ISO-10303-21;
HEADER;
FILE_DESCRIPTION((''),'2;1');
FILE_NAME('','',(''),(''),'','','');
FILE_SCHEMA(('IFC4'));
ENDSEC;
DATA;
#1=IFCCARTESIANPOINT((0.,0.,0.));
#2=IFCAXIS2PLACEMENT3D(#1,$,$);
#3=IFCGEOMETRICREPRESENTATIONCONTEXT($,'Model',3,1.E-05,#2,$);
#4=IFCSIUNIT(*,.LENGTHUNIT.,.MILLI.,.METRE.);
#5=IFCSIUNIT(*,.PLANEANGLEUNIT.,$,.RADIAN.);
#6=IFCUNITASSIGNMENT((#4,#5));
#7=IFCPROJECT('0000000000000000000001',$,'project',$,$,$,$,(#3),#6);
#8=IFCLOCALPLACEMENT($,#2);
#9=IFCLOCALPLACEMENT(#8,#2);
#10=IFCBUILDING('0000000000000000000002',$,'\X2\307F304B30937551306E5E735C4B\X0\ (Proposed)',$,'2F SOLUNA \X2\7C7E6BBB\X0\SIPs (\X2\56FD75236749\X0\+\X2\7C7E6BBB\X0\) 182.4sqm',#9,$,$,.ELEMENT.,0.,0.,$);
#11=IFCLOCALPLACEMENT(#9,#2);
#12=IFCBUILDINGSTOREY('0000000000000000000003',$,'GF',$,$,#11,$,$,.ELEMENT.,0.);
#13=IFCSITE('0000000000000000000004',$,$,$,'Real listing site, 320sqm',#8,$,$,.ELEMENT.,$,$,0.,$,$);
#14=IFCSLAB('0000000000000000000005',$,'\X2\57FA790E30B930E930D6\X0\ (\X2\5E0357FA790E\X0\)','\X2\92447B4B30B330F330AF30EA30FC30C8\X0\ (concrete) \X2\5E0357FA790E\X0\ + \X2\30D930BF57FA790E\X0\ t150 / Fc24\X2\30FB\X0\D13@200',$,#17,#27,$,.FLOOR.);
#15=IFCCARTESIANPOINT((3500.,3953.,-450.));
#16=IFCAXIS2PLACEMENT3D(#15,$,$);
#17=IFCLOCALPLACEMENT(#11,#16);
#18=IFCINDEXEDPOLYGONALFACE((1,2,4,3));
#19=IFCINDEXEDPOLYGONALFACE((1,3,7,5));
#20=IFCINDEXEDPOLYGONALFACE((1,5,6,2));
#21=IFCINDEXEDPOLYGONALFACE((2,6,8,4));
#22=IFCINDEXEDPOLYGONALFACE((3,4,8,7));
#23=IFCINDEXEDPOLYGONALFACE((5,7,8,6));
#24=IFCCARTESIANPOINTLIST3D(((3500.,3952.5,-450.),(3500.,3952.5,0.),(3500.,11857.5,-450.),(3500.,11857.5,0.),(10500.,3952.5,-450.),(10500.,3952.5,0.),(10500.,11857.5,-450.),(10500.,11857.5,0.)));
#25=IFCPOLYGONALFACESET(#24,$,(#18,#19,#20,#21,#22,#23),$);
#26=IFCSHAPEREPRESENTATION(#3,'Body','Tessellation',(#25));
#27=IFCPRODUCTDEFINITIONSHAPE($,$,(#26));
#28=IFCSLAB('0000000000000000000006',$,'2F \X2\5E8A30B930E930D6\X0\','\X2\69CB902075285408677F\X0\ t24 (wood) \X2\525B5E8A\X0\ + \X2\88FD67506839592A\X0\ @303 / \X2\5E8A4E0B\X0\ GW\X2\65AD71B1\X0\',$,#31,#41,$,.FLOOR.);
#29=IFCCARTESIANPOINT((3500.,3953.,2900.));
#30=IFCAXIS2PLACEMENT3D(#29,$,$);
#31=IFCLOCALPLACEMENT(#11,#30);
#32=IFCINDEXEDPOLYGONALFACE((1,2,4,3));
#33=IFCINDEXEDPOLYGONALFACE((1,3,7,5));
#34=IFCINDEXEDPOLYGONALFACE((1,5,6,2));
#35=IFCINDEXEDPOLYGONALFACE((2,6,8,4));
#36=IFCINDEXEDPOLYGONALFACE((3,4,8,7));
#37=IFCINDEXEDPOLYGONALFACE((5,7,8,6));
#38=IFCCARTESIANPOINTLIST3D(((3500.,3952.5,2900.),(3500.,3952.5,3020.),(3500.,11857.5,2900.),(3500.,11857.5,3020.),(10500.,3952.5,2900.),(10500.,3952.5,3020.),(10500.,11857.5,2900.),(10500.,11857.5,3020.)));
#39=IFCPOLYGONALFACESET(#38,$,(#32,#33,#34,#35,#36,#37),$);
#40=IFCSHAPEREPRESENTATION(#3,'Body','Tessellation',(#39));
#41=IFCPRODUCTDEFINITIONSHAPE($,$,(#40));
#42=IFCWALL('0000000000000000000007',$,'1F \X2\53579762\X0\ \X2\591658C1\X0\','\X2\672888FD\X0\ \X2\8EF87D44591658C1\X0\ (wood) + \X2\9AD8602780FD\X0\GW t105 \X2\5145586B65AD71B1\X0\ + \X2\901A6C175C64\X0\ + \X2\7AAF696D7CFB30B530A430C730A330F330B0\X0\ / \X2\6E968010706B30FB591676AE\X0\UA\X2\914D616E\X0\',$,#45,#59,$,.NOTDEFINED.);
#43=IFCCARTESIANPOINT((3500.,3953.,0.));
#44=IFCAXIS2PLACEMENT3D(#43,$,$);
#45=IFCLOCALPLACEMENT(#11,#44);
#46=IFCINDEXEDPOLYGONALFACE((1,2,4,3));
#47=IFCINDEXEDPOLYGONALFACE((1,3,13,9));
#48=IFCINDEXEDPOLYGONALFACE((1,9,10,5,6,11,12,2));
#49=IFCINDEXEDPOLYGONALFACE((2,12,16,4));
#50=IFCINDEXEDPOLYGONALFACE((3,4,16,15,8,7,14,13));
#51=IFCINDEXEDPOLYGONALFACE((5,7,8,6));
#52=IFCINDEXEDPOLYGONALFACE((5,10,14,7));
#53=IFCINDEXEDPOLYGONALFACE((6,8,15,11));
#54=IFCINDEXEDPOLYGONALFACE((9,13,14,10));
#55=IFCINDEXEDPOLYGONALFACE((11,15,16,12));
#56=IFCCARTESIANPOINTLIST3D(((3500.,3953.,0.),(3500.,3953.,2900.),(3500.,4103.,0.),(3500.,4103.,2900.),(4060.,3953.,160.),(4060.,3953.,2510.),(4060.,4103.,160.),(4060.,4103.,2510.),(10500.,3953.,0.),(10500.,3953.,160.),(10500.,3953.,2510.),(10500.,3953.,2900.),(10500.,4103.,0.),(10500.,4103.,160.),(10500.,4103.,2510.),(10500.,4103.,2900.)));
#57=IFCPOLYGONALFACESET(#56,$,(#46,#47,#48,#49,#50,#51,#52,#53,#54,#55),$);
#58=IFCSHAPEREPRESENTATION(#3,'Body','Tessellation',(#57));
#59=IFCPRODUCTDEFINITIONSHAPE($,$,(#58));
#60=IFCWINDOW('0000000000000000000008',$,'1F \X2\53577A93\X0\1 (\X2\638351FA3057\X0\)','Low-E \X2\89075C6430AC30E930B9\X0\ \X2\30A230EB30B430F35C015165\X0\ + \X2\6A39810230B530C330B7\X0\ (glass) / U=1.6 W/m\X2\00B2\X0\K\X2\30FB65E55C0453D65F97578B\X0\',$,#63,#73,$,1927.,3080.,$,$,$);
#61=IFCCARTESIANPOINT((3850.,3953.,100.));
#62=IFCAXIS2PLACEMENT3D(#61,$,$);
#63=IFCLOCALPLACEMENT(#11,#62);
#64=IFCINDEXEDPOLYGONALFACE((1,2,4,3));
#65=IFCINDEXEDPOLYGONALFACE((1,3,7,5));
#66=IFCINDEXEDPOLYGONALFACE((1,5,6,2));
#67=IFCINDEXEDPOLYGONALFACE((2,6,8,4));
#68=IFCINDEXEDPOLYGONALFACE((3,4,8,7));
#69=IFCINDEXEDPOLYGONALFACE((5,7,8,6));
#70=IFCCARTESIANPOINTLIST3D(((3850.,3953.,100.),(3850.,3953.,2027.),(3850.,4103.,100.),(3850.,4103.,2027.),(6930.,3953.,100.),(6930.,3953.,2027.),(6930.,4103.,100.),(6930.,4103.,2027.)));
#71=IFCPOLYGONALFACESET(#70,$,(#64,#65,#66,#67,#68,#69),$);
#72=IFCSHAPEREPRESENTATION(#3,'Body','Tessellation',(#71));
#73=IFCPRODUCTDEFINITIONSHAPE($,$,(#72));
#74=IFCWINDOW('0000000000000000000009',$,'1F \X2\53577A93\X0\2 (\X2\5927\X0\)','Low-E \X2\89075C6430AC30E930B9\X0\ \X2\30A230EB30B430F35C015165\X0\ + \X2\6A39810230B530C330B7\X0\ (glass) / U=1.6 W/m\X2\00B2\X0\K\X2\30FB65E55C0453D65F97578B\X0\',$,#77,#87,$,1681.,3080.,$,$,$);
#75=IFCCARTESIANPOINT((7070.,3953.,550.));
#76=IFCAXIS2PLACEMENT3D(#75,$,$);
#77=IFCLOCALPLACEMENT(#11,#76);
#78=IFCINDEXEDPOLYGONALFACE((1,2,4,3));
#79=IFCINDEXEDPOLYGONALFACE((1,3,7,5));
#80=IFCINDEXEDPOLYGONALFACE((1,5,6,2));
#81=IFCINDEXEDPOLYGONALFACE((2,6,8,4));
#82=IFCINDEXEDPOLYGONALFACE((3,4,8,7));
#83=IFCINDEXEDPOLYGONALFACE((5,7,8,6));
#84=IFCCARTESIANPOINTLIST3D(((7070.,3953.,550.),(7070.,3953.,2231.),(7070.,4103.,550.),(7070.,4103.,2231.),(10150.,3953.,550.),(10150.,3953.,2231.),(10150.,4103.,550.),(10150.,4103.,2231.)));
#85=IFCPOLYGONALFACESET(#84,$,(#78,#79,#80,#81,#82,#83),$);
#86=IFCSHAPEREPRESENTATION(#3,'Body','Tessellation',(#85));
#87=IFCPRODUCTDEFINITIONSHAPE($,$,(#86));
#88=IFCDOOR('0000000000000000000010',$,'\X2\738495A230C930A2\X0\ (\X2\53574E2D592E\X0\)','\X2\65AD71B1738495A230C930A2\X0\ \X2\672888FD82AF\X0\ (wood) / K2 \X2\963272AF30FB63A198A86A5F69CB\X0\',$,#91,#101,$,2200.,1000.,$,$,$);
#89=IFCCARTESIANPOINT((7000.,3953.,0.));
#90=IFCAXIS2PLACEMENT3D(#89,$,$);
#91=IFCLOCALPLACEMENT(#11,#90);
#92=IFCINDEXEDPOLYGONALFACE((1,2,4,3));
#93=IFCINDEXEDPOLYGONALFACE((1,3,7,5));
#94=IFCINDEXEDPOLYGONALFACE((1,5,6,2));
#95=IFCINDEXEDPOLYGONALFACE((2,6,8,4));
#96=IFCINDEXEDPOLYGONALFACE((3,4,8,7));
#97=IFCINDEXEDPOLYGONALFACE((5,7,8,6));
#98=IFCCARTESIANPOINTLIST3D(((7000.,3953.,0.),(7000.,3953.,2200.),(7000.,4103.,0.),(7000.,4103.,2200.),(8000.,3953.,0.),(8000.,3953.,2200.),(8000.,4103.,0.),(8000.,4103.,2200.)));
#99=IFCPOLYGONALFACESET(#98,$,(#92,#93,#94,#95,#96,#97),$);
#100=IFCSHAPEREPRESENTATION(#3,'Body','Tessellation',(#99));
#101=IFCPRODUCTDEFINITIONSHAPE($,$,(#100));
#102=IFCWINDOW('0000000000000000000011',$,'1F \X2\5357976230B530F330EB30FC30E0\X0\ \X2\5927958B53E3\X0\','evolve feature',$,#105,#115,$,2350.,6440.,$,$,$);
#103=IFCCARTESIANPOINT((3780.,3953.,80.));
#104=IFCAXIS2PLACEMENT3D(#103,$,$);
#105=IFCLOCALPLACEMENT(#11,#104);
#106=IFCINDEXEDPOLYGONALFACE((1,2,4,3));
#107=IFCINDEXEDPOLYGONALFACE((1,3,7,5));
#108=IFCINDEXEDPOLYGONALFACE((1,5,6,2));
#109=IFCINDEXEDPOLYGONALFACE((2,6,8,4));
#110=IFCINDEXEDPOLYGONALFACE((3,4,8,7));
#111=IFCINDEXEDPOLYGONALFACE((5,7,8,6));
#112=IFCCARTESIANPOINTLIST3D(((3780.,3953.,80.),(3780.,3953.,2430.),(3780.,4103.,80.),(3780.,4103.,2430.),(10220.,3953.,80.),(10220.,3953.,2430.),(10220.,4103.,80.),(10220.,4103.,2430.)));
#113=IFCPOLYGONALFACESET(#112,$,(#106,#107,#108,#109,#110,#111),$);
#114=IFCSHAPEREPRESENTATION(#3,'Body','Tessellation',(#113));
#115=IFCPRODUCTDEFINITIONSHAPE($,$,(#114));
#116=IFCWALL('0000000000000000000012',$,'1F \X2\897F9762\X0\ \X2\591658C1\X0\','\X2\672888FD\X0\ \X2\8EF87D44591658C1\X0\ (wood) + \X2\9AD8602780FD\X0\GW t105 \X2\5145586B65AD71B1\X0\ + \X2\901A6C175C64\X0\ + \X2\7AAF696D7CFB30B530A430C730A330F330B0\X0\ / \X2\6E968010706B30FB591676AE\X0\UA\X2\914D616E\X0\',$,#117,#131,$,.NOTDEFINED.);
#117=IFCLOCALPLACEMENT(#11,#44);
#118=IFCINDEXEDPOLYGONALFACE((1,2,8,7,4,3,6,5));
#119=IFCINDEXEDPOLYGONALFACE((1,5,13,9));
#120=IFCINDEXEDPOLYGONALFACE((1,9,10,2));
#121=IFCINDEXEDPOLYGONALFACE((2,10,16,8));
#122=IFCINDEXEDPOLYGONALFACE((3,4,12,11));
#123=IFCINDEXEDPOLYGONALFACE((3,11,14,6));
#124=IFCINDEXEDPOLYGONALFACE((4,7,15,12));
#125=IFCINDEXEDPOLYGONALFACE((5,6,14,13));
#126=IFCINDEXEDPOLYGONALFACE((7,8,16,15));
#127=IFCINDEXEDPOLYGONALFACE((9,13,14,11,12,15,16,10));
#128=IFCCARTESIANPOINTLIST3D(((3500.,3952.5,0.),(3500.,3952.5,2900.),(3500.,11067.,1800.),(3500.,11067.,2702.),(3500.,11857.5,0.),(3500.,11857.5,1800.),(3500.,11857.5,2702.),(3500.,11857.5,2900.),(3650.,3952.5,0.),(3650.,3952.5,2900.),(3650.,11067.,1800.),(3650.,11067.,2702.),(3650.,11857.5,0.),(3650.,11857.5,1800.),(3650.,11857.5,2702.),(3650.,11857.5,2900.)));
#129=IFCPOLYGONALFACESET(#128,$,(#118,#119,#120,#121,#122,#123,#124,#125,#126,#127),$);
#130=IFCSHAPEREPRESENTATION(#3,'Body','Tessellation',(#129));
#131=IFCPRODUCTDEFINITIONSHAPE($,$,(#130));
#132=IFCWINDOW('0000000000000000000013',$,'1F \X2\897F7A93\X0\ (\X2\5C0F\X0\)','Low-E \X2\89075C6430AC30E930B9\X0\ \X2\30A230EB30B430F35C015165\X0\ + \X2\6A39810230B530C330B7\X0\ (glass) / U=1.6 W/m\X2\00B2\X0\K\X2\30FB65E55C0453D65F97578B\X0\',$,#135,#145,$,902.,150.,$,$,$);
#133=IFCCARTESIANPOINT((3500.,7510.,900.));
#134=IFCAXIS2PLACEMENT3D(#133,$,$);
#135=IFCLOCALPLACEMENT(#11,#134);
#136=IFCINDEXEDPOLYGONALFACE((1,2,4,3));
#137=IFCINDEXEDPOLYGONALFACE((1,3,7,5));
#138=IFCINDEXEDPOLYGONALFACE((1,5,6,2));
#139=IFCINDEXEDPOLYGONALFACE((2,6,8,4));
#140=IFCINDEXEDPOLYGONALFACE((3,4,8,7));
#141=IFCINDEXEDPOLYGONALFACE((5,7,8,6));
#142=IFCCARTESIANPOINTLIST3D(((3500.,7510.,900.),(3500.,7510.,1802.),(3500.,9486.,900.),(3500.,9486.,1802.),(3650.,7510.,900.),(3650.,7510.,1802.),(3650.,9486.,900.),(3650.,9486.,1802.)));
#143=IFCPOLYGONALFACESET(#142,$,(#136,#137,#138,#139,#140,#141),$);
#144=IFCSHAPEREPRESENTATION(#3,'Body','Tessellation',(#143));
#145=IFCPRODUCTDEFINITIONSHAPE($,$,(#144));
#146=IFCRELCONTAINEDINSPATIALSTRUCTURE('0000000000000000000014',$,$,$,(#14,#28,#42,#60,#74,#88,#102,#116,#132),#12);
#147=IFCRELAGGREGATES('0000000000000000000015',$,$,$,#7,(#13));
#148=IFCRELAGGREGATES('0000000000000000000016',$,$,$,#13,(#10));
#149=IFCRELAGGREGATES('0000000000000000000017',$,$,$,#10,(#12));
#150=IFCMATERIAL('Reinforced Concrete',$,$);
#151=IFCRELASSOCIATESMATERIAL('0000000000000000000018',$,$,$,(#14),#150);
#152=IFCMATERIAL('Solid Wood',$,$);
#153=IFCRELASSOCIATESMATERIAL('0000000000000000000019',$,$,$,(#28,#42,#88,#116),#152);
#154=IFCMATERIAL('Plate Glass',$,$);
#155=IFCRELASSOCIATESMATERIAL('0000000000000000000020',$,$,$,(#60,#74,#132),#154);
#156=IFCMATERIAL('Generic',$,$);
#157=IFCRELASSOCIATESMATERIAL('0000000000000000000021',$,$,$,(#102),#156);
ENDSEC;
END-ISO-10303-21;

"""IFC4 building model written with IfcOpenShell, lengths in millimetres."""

from ifc_helpers import new_model, si_unit, frame, frame_2d, origin, place, context, project, spatial, rectangle, extrude, material, element, fill, save


model = new_model("IFC4")

# Units and contexts
model_context = context("Model", 3, precision=1e-05, world=origin())
ifc_project = project(units=[si_unit("LENGTHUNIT", "METRE", prefix="MILLI"), si_unit("PLANEANGLEUNIT", "RADIAN")], contexts=[model_context])

# Site, building, storey
site_placement = place(None, origin())
site = spatial("IfcSite", under=ifc_project, at=site_placement, ObjectType="Real listing site, 320sqm", CompositionType="ELEMENT", RefElevation=0.0)
building_placement = place(site_placement, origin())
building = spatial("IfcBuilding", under=site, at=building_placement, Name="みかん畑の平屋 (Proposed)", ObjectType="2F SOLUNA 籾殻SIPs (国産杉+籾殻) 182.4sqm", CompositionType="ELEMENT", ElevationOfRefHeight=0.0, ElevationOfTerrain=0.0)
storey_placement = place(building_placement, origin())
storey = spatial("IfcBuildingStorey", under=building, at=storey_placement, Name="GF", CompositionType="ELEMENT", Elevation=0.0)

# Slabs
ifc_material_1 = material(Name="Reinforced Concrete")
slab_1_placement = place(storey_placement, frame((3500.0, 3953.0, -450.0)))
element("IfcSlab", 1, at=slab_1_placement, inside=storey, material=ifc_material_1, Name="基礎スラブ (布基礎)", Description="鉄筋コンクリート (concrete) 布基礎 + ベタ基礎 t150 / Fc24・D13@200", PredefinedType="FLOOR", context=model_context, shape_type="SweptSolid", body=[
    extrude(rectangle(XDim=7000.0, YDim=7905.0, at=frame_2d((3500.0, 3952.0))), frame((3500.0, 3953.0, -450.0)), (0.0, 0.0, 1.0), 450.0),
])
ifc_material_2 = material(Name="Solid Wood")
slab_2_placement = place(storey_placement, frame((3500.0, 3953.0, 2900.0)))
element("IfcSlab", 2, at=slab_2_placement, inside=storey, material=ifc_material_2, Name="2F 床スラブ", Description="構造用合板 t24 (wood) 剛床 + 製材根太 @303 / 床下 GW断熱", PredefinedType="FLOOR", context=model_context, shape_type="SweptSolid", body=[
    extrude(rectangle(XDim=7000.0, YDim=7905.0, at=frame_2d((3500.0, 3952.0))), frame((3500.0, 3953.0, 2900.0)), (0.0, 0.0, 1.0), 120.0),
])
ifc_material_3 = material(Name="Generic")

# Wall, openings, windows, door
wall_1_placement = place(storey_placement, frame((3500.0, 3953.0, 0.0)))
wall_1 = element("IfcWall", 3, at=wall_1_placement, inside=storey, material=ifc_material_2, Name="1F 南面 外壁", Description="木製 軸組外壁 (wood) + 高性能GW t105 充填断熱 + 通気層 + 窯業系サイディング / 準耐火・外皮UA配慮", PredefinedType="NOTDEFINED", context=model_context, shape_type="SweptSolid", body=[
    extrude(rectangle(XDim=7000.0, YDim=150.0, at=frame_2d((3500.0, 75.0))), frame((3500.0, 3953.0, 0.0)), (0.0, 0.0, 1.0), 2900.0),
])
opening_1_placement = place(storey_placement, frame((3850.0, 3953.0, 100.0)))
opening_1 = element("IfcOpeningElement", 4, at=opening_1_placement, cuts=wall_1, PredefinedType="NOTDEFINED", context=model_context, shape_type="SweptSolid", body=[
    extrude(rectangle(XDim=3080.0, YDim=150.0, at=frame_2d((1540.0, 75.0))), frame((3850.0, 3953.0, 100.0)), (0.0, 0.0, 1.0), 1927.0),
])
opening_2_placement = place(storey_placement, frame((7070.0, 3953.0, 550.0)))
opening_2 = element("IfcOpeningElement", 5, at=opening_2_placement, cuts=wall_1, PredefinedType="NOTDEFINED", context=model_context, shape_type="SweptSolid", body=[
    extrude(rectangle(XDim=3080.0, YDim=150.0, at=frame_2d((1540.0, 75.0))), frame((7070.0, 3953.0, 550.0)), (0.0, 0.0, 1.0), 1681.0),
])
opening_3_placement = place(storey_placement, frame((7000.0, 3953.0, 0.0)))
opening_3 = element("IfcOpeningElement", 6, at=opening_3_placement, cuts=wall_1, PredefinedType="NOTDEFINED", context=model_context, shape_type="SweptSolid", body=[
    extrude(rectangle(XDim=1000.0, YDim=150.0, at=frame_2d((500.0, 75.0))), frame((7000.0, 3953.0, 0.0)), (0.0, 0.0, 1.0), 2200.0),
])
opening_4_placement = place(storey_placement, frame((3780.0, 3953.0, 80.0)))
opening_4 = element("IfcOpeningElement", 7, at=opening_4_placement, cuts=wall_1, PredefinedType="NOTDEFINED", context=model_context, shape_type="SweptSolid", body=[
    extrude(rectangle(XDim=6440.0, YDim=150.0, at=frame_2d((3220.0, 75.0))), frame((3780.0, 3953.0, 80.0)), (0.0, 0.0, 1.0), 2350.0),
])
ifc_material_4 = material(Name="Plate Glass")
window_1_placement = place(storey_placement, frame((3850.0, 3953.0, 100.0)))
window_1 = element("IfcWindow", 8, at=window_1_placement, inside=storey, material=ifc_material_4, Name="1F 南窓1 (掃出し)", Description="Low-E 複層ガラス アルゴン封入 + 樹脂サッシ (glass) / U=1.6 W/m²K・日射取得型", OverallHeight=1927.0, OverallWidth=3080.0, context=model_context, shape_type="SweptSolid", body=[
    extrude(rectangle(XDim=3080.0, YDim=150.0, at=frame_2d((1540.0, 75.0))), frame((3850.0, 3953.0, 100.0)), (0.0, 0.0, 1.0), 1927.0),
])
fill(opening_1, window_1)
window_2_placement = place(storey_placement, frame((7070.0, 3953.0, 550.0)))
window_2 = element("IfcWindow", 9, at=window_2_placement, inside=storey, material=ifc_material_4, Name="1F 南窓2 (大)", Description="Low-E 複層ガラス アルゴン封入 + 樹脂サッシ (glass) / U=1.6 W/m²K・日射取得型", OverallHeight=1681.0, OverallWidth=3080.0, context=model_context, shape_type="SweptSolid", body=[
    extrude(rectangle(XDim=3080.0, YDim=150.0, at=frame_2d((1540.0, 75.0))), frame((7070.0, 3953.0, 550.0)), (0.0, 0.0, 1.0), 1681.0),
])
fill(opening_2, window_2)
door_placement = place(storey_placement, frame((7000.0, 3953.0, 0.0)))
door = element("IfcDoor", 10, at=door_placement, inside=storey, material=ifc_material_2, Name="玄関ドア (南中央)", Description="断熱玄関ドア 木製芯 (wood) / K2 防犯・採風機構", OverallHeight=2200.0, OverallWidth=1000.0, context=model_context, shape_type="SweptSolid", body=[
    extrude(rectangle(XDim=1000.0, YDim=150.0, at=frame_2d((500.0, 75.0))), frame((7000.0, 3953.0, 0.0)), (0.0, 0.0, 1.0), 2200.0),
])
fill(opening_3, door)
window_3_placement = place(storey_placement, frame((3780.0, 3953.0, 80.0)))
window_3 = element("IfcWindow", 11, at=window_3_placement, inside=storey, material=ifc_material_3, Name="1F 南面サンルーム 大開口", Description="evolve feature", OverallHeight=2350.0, OverallWidth=6440.0, context=model_context, shape_type="SweptSolid", body=[
    extrude(rectangle(XDim=6440.0, YDim=150.0, at=frame_2d((3220.0, 75.0))), frame((3780.0, 3953.0, 80.0)), (0.0, 0.0, 1.0), 2350.0),
])
fill(opening_4, window_3)

# Wall, opening, window
wall_2_placement = place(storey_placement, frame((3500.0, 3953.0, 0.0)))
wall_2 = element("IfcWall", 12, at=wall_2_placement, inside=storey, material=ifc_material_2, Name="1F 西面 外壁", Description="木製 軸組外壁 (wood) + 高性能GW t105 充填断熱 + 通気層 + 窯業系サイディング / 準耐火・外皮UA配慮", PredefinedType="NOTDEFINED", context=model_context, shape_type="SweptSolid", body=[
    extrude(rectangle(XDim=150.0, YDim=7905.0, at=frame_2d((75.0, 3952.0))), frame((3500.0, 3953.0, 0.0)), (0.0, 0.0, 1.0), 2900.0),
])
opening_5_placement = place(storey_placement, frame((3500.0, 7510.0, 900.0)))
opening_5 = element("IfcOpeningElement", 13, at=opening_5_placement, cuts=wall_2, PredefinedType="NOTDEFINED", context=model_context, shape_type="SweptSolid", body=[
    extrude(rectangle(XDim=150.0, YDim=1976.0, at=frame_2d((75.0, 988.0))), frame((3500.0, 7510.0, 900.0)), (0.0, 0.0, 1.0), 902.0),
])
window_4_placement = place(storey_placement, frame((3500.0, 7510.0, 900.0)))
window_4 = element("IfcWindow", 14, at=window_4_placement, inside=storey, material=ifc_material_4, Name="1F 西窓 (小)", Description="Low-E 複層ガラス アルゴン封入 + 樹脂サッシ (glass) / U=1.6 W/m²K・日射取得型", OverallHeight=902.0, OverallWidth=150.0, context=model_context, shape_type="SweptSolid", body=[
    extrude(rectangle(XDim=150.0, YDim=1976.0, at=frame_2d((75.0, 988.0))), frame((3500.0, 7510.0, 900.0)), (0.0, 0.0, 1.0), 902.0),
])
fill(opening_5, window_4)

save(model, "model.ifc")
